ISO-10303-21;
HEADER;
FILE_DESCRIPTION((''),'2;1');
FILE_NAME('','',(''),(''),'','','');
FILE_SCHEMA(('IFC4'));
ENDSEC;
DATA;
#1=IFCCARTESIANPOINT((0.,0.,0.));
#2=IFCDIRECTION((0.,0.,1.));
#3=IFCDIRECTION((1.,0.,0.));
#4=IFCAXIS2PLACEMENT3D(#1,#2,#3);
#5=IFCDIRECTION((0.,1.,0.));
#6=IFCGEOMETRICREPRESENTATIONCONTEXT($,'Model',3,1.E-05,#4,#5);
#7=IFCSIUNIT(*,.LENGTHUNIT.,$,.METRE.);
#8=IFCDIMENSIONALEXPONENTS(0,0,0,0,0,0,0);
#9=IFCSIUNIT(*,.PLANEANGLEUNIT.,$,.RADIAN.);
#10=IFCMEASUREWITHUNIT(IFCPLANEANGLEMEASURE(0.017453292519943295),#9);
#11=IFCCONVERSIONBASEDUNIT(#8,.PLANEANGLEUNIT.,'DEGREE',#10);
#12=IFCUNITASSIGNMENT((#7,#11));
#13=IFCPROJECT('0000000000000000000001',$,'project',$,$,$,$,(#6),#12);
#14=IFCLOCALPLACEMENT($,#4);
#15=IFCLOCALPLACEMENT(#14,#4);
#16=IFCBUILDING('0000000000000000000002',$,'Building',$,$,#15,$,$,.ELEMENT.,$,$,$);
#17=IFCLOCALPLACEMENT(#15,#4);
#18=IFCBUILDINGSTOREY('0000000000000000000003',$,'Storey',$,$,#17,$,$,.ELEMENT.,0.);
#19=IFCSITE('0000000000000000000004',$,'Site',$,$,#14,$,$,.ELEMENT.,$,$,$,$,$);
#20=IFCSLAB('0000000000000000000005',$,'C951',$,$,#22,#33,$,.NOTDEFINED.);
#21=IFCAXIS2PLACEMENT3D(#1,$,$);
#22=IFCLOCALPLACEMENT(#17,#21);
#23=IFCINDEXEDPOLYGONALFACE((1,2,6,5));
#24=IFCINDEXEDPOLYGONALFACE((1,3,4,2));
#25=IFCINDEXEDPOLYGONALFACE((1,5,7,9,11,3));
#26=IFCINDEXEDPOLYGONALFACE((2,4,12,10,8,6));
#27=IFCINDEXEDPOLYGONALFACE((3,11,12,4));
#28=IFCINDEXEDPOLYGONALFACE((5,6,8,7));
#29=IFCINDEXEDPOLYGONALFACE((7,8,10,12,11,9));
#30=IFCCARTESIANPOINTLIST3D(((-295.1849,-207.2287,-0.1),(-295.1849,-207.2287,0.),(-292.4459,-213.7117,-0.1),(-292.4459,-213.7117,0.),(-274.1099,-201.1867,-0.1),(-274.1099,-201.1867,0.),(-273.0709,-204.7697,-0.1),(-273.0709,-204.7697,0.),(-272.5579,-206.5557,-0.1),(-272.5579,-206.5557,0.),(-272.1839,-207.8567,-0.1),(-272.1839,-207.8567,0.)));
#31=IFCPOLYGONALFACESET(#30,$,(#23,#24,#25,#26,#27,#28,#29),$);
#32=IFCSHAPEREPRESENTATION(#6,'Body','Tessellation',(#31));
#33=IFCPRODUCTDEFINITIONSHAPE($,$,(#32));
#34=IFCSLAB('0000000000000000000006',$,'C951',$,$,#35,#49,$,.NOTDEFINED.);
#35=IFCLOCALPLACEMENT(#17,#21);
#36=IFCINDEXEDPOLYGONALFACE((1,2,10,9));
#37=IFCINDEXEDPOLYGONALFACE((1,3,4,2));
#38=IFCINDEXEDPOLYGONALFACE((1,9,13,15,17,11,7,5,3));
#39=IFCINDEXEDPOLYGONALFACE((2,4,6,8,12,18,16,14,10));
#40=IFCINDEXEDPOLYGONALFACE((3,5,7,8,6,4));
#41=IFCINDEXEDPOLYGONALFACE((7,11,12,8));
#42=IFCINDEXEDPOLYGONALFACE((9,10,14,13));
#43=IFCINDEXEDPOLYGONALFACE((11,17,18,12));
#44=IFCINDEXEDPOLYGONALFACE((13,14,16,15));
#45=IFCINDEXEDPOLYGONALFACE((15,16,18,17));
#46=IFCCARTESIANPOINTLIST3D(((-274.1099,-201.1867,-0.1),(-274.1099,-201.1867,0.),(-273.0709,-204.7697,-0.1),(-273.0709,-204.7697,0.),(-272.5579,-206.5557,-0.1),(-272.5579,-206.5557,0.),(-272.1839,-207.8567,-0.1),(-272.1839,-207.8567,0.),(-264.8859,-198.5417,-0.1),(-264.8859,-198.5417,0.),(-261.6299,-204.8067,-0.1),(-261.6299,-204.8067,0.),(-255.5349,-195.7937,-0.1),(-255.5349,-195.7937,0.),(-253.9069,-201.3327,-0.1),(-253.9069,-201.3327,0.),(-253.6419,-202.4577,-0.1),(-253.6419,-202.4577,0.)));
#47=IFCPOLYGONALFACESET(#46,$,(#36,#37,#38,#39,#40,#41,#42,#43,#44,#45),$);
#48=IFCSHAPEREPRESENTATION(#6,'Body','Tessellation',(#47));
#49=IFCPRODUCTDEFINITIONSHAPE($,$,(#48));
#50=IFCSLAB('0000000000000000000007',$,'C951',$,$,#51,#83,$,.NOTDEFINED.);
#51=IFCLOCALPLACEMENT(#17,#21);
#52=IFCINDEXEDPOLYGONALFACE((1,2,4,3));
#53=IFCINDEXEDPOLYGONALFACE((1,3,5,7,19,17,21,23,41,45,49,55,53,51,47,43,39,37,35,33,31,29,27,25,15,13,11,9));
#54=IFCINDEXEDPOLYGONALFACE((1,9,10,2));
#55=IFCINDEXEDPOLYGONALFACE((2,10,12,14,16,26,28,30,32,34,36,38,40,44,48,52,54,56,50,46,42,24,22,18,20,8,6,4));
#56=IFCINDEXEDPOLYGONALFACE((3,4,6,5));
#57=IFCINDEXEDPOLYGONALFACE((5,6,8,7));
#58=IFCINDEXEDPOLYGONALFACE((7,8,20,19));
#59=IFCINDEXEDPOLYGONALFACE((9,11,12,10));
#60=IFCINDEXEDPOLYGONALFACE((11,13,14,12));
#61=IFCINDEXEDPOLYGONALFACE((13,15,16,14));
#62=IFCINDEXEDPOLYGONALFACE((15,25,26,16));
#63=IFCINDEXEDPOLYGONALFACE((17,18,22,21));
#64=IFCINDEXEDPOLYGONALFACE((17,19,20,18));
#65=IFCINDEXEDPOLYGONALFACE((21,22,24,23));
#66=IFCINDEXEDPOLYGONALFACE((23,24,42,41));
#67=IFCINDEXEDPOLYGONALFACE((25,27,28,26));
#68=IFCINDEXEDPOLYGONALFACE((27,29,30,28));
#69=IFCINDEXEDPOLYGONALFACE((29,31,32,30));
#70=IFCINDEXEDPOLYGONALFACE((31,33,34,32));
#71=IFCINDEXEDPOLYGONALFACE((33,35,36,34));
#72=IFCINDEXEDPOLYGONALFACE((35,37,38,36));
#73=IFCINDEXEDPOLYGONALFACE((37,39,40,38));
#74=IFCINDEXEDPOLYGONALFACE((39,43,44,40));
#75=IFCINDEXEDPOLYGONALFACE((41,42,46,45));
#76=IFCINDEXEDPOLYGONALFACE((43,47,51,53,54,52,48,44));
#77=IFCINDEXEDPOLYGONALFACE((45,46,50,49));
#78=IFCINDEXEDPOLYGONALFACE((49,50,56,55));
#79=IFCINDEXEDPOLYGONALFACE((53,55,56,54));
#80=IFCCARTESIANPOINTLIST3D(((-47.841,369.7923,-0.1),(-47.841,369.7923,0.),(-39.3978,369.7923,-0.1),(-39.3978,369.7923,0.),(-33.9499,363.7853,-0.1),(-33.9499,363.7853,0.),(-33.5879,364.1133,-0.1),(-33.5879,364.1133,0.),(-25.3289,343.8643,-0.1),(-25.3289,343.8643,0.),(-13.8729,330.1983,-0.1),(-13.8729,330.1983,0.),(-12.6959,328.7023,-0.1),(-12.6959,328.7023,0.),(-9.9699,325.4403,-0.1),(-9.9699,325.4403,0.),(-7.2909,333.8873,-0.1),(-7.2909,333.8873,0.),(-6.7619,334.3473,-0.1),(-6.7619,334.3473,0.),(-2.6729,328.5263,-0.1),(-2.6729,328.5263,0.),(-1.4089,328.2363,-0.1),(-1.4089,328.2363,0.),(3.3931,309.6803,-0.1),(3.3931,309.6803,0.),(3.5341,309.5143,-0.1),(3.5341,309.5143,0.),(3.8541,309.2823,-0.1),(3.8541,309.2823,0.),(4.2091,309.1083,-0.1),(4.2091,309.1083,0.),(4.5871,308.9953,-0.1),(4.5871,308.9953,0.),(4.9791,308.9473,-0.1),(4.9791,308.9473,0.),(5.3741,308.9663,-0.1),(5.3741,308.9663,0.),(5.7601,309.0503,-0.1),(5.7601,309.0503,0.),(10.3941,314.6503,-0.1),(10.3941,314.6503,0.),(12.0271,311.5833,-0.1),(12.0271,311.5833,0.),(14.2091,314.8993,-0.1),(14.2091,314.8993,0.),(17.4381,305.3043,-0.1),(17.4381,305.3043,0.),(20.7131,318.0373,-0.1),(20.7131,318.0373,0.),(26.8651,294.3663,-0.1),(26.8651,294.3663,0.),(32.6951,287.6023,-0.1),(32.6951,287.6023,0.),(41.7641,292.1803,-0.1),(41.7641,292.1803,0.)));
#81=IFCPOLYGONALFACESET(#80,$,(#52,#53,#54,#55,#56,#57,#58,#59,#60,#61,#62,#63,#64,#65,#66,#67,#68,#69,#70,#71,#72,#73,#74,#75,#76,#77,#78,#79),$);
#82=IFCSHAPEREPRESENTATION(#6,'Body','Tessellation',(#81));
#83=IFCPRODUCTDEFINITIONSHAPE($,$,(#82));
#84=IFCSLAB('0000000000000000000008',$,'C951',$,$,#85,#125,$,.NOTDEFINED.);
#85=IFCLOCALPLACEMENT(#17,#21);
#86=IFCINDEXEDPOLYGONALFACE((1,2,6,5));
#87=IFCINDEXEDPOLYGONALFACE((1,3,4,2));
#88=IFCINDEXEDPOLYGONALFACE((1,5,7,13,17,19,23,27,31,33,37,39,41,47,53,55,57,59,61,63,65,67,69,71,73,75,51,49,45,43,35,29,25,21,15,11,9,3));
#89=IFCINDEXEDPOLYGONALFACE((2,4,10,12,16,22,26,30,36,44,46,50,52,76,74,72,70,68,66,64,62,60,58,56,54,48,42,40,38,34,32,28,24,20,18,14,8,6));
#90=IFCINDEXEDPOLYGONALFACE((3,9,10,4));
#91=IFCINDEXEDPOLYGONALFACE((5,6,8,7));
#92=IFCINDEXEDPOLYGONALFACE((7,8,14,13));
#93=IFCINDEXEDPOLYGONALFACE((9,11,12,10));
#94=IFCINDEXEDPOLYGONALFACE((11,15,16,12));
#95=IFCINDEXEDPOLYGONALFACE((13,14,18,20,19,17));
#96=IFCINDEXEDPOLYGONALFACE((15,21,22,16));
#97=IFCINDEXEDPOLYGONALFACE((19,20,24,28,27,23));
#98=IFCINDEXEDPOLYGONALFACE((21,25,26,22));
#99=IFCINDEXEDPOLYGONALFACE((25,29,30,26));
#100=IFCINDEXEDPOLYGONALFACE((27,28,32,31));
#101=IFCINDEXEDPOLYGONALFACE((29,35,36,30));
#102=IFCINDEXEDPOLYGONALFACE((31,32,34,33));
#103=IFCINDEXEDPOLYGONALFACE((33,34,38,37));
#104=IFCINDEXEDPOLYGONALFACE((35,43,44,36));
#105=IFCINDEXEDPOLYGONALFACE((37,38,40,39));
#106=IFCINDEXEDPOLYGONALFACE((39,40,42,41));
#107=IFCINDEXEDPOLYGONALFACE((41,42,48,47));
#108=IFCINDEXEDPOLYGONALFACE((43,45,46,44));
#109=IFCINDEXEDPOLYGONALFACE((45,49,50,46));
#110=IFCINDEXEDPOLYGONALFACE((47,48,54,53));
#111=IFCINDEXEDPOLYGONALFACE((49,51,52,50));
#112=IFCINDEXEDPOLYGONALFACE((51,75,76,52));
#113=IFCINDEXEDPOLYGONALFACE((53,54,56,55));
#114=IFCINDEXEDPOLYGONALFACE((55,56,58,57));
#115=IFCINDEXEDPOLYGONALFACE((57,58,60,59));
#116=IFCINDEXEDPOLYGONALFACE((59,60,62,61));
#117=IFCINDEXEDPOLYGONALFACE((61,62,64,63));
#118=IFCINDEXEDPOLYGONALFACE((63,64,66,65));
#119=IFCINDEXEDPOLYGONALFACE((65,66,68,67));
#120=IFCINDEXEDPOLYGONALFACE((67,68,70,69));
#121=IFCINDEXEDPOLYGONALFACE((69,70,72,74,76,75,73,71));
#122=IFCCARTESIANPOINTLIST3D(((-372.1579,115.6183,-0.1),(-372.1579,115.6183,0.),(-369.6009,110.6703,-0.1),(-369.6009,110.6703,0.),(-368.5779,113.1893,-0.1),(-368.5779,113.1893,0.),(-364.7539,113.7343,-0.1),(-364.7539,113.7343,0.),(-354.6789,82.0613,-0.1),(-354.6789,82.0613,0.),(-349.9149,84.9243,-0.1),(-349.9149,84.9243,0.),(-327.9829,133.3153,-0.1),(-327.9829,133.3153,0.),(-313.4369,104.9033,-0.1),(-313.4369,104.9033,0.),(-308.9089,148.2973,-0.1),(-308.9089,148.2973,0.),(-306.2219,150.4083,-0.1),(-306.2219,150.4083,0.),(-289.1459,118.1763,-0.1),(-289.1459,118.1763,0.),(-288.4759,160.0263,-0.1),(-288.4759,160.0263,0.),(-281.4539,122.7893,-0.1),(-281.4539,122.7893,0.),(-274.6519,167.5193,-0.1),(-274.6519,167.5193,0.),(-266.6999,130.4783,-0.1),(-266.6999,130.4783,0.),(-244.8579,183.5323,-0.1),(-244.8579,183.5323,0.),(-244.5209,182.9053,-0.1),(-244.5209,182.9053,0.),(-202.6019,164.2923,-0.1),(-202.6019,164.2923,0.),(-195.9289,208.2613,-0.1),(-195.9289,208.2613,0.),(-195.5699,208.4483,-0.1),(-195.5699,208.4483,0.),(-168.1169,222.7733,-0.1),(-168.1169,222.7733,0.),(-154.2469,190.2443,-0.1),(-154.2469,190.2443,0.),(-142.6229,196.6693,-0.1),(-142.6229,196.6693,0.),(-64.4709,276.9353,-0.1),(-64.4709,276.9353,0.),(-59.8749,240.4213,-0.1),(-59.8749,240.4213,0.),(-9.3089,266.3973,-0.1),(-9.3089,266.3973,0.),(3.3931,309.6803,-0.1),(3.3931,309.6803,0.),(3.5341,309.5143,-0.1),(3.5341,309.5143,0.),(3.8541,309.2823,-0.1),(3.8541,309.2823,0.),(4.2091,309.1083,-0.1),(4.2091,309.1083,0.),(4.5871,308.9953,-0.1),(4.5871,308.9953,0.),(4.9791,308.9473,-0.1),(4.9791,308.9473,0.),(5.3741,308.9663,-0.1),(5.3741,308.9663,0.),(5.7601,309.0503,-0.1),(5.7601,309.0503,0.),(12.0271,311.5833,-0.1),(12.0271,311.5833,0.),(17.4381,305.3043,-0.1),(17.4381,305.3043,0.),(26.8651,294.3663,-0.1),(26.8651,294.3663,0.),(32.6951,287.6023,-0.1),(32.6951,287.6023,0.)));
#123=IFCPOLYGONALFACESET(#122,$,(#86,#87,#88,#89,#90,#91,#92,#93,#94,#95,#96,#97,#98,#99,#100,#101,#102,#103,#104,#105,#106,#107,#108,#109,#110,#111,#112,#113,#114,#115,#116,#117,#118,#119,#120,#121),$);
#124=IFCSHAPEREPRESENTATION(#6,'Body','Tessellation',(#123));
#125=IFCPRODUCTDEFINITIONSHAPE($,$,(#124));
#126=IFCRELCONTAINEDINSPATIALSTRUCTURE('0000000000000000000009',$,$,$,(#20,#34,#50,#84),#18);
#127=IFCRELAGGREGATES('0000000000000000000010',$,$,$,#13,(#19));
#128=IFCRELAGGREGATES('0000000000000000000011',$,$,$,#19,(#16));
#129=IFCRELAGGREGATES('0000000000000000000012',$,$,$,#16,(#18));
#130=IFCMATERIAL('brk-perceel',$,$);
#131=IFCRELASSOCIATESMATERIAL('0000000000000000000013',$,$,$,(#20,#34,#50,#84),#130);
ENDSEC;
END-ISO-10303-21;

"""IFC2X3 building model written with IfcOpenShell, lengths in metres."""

from ifc_helpers import new_model, entity, si_unit, converted_unit, direction, frame, origin_with_axes, place, context, project, spatial, polyline, outline, extrude, material, element, save


model = new_model("IFC2X3")

# Units and contexts
model_context = context("Model", 3, precision=1e-05, world=origin_with_axes(), true_north=direction((0.0, 1.0, 0.0)))
ifc_project = project(units=[si_unit("LENGTHUNIT", "METRE"), converted_unit("PLANEANGLEUNIT", "DEGREE", entity("IfcPlaneAngleMeasure", 0.017453292519943295), si_unit("PLANEANGLEUNIT", "RADIAN"), dimensions=[0, 0, 0, 0, 0, 0, 0])], contexts=[model_context])

# Site, building, storey
site_placement = place(None, origin_with_axes())
site = spatial("IfcSite", under=ifc_project, at=site_placement, Name="Site", CompositionType="ELEMENT")
building_placement = place(site_placement, origin_with_axes())
building = spatial("IfcBuilding", under=site, at=building_placement, Name="Building", CompositionType="ELEMENT")
storey_placement = place(building_placement, origin_with_axes())
storey = spatial("IfcBuildingStorey", under=building, at=storey_placement, Name="Storey", CompositionType="ELEMENT", Elevation=0.0)

# Slabs
ifc_material = material(Name="brk-perceel")
slab_1_placement = place(storey_placement, frame((0.0, 0.0, -0.1), z_axis=(0.0, 0.0, 1.0), x_axis=(1.0, 0.0, 0.0)))
element("IfcSlab", 1, at=slab_1_placement, inside=storey, material=ifc_material, Name="C951", PredefinedType="NOTDEFINED", context=model_context, shape_type="SweptSolid", body=[
    extrude(outline(polyline([(-273.0709, -204.7697), (-272.5579, -206.5557), (-272.1839, -207.8567), (-292.4459, -213.7117), (-295.1849, -207.2287), (-274.1099, -201.1867), (-273.0709, -204.7697)])), origin_with_axes(), (0.0, 0.0, 1.0), 0.1),
])
slab_2_placement = place(storey_placement, frame((0.0, 0.0, -0.1), z_axis=(0.0, 0.0, 1.0), x_axis=(1.0, 0.0, 0.0)))
element("IfcSlab", 2, at=slab_2_placement, inside=storey, material=ifc_material, Name="C951", PredefinedType="NOTDEFINED", context=model_context, shape_type="SweptSolid", body=[
    extrude(outline(polyline([(-261.6299, -204.8067), (-272.1839, -207.8567), (-272.5579, -206.5557), (-273.0709, -204.7697), (-274.1099, -201.1867), (-264.8859, -198.5417), (-255.5349, -195.7937), (-253.9069, -201.3327), (-253.6419, -202.4577), (-261.6299, -204.8067)])), origin_with_axes(), (0.0, 0.0, 1.0), 0.1),
])
slab_3_placement = place(storey_placement, frame((0.0, 0.0, -0.1), z_axis=(0.0, 0.0, 1.0), x_axis=(1.0, 0.0, 0.0)))
element("IfcSlab", 3, at=slab_3_placement, inside=storey, material=ifc_material, Name="C951", PredefinedType="NOTDEFINED", context=model_context, shape_type="SweptSolid", body=[
    extrude(outline(polyline([(-33.9499, 363.7853), (-33.5879, 364.1133), (-6.7619, 334.3473), (-7.2909, 333.8873), (-2.6729, 328.5263), (-1.4089, 328.2363), (10.3941, 314.6503), (14.2091, 314.8993), (20.7131, 318.0373), (41.7641, 292.1803), (32.6951, 287.6023), (26.8651, 294.3663), (17.4381, 305.3043), (12.0271, 311.5833), (5.7601, 309.0503), (5.3741, 308.9663), (4.9791, 308.9473), (4.5871, 308.9953), (4.2091, 309.1083), (3.8541, 309.2823), (3.5341, 309.5143), (3.3931, 309.6803), (-9.9699, 325.4403), (-12.6959, 328.7023), (-13.8729, 330.1983), (-25.3289, 343.8643), (-47.841, 369.7923), (-39.3978, 369.7923), (-33.9499, 363.7853)])), origin_with_axes(), (0.0, 0.0, 1.0), 0.1),
])
slab_4_placement = place(storey_placement, frame((0.0, 0.0, -0.1), z_axis=(0.0, 0.0, 1.0), x_axis=(1.0, 0.0, 0.0)))
element("IfcSlab", 4, at=slab_4_placement, inside=storey, material=ifc_material, Name="C951", PredefinedType="NOTDEFINED", context=model_context, shape_type="SweptSolid", body=[
    extrude(outline(polyline([(-372.1579, 115.6183), (-368.5779, 113.1893), (-364.7539, 113.7343), (-327.9829, 133.3153), (-308.9089, 148.2973), (-306.2219, 150.4083), (-288.4759, 160.0263), (-274.6519, 167.5193), (-244.8579, 183.5323), (-244.5209, 182.9053), (-195.9289, 208.2613), (-195.5699, 208.4483), (-168.1169, 222.7733), (-64.4709, 276.9353), (3.3931, 309.6803), (3.5341, 309.5143), (3.8541, 309.2823), (4.2091, 309.1083), (4.5871, 308.9953), (4.9791, 308.9473), (5.3741, 308.9663), (5.7601, 309.0503), (12.0271, 311.5833), (17.4381, 305.3043), (26.8651, 294.3663), (32.6951, 287.6023), (-9.3089, 266.3973), (-59.8749, 240.4213), (-142.6229, 196.6693), (-154.2469, 190.2443), (-202.6019, 164.2923), (-266.6999, 130.4783), (-281.4539, 122.7893), (-289.1459, 118.1763), (-313.4369, 104.9033), (-349.9149, 84.9243), (-354.6789, 82.0613), (-369.6009, 110.6703), (-372.1579, 115.6183)])), origin_with_axes(), (0.0, 0.0, 1.0), 0.1),
])

save(model, "model.ifc")
